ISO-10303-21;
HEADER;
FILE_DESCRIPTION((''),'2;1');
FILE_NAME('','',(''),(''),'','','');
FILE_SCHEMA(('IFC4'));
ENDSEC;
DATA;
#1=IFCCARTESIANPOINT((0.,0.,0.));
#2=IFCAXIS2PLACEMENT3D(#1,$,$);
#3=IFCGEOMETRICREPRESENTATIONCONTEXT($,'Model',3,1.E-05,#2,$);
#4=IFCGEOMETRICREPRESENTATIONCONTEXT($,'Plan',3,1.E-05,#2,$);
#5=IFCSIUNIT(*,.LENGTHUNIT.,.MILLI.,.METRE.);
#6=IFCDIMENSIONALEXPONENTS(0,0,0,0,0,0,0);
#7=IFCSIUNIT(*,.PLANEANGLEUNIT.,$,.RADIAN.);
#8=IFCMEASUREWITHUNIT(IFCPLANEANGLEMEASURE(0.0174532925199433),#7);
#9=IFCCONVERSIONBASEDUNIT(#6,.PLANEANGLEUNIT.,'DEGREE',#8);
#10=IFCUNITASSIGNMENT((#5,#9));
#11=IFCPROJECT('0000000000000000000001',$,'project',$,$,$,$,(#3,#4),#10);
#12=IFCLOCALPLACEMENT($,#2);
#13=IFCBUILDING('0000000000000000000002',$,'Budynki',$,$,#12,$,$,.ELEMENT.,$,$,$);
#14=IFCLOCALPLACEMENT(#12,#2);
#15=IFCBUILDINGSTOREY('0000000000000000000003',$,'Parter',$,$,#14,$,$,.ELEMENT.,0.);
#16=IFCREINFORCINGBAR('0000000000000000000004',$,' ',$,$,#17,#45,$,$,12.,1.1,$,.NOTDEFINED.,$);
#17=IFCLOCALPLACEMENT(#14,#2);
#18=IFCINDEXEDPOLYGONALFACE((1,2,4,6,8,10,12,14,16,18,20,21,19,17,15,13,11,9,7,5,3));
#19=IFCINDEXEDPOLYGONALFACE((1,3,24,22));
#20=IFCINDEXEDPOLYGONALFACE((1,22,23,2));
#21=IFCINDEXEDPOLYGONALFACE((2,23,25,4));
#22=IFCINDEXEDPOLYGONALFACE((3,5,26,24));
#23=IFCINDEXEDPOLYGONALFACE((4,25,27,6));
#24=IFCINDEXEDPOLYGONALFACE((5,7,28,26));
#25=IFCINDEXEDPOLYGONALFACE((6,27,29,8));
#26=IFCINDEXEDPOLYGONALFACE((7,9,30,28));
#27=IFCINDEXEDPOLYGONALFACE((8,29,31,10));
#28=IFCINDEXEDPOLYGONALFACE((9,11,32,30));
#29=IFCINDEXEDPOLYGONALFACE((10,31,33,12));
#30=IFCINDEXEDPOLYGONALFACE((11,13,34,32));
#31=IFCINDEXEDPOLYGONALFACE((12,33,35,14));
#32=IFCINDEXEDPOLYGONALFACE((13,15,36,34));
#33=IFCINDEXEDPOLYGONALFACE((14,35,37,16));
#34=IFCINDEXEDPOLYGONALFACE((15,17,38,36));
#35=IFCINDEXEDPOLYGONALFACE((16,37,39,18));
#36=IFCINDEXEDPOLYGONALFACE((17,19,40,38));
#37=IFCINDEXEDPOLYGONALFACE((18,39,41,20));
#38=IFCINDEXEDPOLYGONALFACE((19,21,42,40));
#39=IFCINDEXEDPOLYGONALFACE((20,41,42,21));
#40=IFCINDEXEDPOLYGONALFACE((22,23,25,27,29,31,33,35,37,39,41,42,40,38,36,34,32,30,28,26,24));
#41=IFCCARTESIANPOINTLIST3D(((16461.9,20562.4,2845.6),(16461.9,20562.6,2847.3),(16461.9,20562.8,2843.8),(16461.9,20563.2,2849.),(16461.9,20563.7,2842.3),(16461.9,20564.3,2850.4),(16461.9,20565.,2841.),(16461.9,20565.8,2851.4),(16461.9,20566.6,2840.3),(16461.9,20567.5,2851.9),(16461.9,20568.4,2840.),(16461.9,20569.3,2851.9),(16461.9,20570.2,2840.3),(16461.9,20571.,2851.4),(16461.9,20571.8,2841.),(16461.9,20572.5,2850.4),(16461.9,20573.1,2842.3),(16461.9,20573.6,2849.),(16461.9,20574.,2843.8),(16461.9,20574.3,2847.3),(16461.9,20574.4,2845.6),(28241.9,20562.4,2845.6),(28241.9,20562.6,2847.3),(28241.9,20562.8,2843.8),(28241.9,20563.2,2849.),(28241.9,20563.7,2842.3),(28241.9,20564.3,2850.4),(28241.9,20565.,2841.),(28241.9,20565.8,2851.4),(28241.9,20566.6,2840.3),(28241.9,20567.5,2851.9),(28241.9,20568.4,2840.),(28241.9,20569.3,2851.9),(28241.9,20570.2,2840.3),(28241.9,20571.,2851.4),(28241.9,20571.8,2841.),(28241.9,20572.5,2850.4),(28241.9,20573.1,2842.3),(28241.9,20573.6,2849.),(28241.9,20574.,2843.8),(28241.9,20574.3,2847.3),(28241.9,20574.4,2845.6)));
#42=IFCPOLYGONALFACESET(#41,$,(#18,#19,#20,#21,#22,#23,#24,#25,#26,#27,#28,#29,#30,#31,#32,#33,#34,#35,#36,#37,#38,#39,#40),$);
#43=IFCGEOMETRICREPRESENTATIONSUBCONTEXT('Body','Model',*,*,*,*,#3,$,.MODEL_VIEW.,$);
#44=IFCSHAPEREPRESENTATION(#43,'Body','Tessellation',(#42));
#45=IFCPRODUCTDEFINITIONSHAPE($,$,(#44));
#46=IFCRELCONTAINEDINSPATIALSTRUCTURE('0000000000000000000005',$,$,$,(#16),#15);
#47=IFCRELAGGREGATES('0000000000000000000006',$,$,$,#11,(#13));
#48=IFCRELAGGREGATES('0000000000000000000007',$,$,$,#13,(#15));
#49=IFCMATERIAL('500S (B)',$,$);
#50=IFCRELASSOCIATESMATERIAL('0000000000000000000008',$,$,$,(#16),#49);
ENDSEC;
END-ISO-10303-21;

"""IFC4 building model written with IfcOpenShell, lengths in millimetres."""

from ifc_helpers import new_model, entity, si_unit, converted_unit, frame, origin, place, context, subcontext, project, spatial, material, element, save


model = new_model("IFC4")

# Units and contexts
model_context = context("Model", 3, precision=1e-05, world=origin())
plan_context = context("Plan", 3, precision=1e-05, world=origin())
body_context = subcontext(model_context, "Body", "Model", "MODEL_VIEW")
ifc_project = project(units=[si_unit("LENGTHUNIT", "METRE", prefix="MILLI"), converted_unit("PLANEANGLEUNIT", "DEGREE", entity("IfcPlaneAngleMeasure", 0.0174532925199433), si_unit("PLANEANGLEUNIT", "RADIAN"), dimensions=[0, 0, 0, 0, 0, 0, 0])], contexts=[model_context, plan_context])

# Building, storey
building_placement = place(None, origin())
building = spatial("IfcBuilding", under=ifc_project, at=building_placement, Name="Budynki", CompositionType="ELEMENT")
storey_placement = place(building_placement, origin())
storey = spatial("IfcBuildingStorey", under=building, at=storey_placement, Name="Parter", CompositionType="ELEMENT", Elevation=0.0)

# Reinforcing bar
ifc_material_1 = material(Name="500S (B)")
reinforcing_bar_1_placement = place(storey_placement, frame((28241.9, 20568.4, 2846.0)))
element("IfcReinforcingBar", 1, at=reinforcing_bar_1_placement, inside=storey, material=ifc_material_1, Name=" ", CrossSectionArea=1.1, NominalDiameter=12.0, PredefinedType="NOTDEFINED", context=body_context, shape_type="AdvancedSweptSolid", body=[
    entity("IfcSweptDiskSolid", entity("IfcPolyline", [entity("IfcCartesianPoint", [0.0, 0.0, 0.0]), entity("IfcCartesianPoint", [-11780.0, 0.0, 0.0])]), 6.0, None, 0.0, 1.0),
])

save(model, "model.ifc")
